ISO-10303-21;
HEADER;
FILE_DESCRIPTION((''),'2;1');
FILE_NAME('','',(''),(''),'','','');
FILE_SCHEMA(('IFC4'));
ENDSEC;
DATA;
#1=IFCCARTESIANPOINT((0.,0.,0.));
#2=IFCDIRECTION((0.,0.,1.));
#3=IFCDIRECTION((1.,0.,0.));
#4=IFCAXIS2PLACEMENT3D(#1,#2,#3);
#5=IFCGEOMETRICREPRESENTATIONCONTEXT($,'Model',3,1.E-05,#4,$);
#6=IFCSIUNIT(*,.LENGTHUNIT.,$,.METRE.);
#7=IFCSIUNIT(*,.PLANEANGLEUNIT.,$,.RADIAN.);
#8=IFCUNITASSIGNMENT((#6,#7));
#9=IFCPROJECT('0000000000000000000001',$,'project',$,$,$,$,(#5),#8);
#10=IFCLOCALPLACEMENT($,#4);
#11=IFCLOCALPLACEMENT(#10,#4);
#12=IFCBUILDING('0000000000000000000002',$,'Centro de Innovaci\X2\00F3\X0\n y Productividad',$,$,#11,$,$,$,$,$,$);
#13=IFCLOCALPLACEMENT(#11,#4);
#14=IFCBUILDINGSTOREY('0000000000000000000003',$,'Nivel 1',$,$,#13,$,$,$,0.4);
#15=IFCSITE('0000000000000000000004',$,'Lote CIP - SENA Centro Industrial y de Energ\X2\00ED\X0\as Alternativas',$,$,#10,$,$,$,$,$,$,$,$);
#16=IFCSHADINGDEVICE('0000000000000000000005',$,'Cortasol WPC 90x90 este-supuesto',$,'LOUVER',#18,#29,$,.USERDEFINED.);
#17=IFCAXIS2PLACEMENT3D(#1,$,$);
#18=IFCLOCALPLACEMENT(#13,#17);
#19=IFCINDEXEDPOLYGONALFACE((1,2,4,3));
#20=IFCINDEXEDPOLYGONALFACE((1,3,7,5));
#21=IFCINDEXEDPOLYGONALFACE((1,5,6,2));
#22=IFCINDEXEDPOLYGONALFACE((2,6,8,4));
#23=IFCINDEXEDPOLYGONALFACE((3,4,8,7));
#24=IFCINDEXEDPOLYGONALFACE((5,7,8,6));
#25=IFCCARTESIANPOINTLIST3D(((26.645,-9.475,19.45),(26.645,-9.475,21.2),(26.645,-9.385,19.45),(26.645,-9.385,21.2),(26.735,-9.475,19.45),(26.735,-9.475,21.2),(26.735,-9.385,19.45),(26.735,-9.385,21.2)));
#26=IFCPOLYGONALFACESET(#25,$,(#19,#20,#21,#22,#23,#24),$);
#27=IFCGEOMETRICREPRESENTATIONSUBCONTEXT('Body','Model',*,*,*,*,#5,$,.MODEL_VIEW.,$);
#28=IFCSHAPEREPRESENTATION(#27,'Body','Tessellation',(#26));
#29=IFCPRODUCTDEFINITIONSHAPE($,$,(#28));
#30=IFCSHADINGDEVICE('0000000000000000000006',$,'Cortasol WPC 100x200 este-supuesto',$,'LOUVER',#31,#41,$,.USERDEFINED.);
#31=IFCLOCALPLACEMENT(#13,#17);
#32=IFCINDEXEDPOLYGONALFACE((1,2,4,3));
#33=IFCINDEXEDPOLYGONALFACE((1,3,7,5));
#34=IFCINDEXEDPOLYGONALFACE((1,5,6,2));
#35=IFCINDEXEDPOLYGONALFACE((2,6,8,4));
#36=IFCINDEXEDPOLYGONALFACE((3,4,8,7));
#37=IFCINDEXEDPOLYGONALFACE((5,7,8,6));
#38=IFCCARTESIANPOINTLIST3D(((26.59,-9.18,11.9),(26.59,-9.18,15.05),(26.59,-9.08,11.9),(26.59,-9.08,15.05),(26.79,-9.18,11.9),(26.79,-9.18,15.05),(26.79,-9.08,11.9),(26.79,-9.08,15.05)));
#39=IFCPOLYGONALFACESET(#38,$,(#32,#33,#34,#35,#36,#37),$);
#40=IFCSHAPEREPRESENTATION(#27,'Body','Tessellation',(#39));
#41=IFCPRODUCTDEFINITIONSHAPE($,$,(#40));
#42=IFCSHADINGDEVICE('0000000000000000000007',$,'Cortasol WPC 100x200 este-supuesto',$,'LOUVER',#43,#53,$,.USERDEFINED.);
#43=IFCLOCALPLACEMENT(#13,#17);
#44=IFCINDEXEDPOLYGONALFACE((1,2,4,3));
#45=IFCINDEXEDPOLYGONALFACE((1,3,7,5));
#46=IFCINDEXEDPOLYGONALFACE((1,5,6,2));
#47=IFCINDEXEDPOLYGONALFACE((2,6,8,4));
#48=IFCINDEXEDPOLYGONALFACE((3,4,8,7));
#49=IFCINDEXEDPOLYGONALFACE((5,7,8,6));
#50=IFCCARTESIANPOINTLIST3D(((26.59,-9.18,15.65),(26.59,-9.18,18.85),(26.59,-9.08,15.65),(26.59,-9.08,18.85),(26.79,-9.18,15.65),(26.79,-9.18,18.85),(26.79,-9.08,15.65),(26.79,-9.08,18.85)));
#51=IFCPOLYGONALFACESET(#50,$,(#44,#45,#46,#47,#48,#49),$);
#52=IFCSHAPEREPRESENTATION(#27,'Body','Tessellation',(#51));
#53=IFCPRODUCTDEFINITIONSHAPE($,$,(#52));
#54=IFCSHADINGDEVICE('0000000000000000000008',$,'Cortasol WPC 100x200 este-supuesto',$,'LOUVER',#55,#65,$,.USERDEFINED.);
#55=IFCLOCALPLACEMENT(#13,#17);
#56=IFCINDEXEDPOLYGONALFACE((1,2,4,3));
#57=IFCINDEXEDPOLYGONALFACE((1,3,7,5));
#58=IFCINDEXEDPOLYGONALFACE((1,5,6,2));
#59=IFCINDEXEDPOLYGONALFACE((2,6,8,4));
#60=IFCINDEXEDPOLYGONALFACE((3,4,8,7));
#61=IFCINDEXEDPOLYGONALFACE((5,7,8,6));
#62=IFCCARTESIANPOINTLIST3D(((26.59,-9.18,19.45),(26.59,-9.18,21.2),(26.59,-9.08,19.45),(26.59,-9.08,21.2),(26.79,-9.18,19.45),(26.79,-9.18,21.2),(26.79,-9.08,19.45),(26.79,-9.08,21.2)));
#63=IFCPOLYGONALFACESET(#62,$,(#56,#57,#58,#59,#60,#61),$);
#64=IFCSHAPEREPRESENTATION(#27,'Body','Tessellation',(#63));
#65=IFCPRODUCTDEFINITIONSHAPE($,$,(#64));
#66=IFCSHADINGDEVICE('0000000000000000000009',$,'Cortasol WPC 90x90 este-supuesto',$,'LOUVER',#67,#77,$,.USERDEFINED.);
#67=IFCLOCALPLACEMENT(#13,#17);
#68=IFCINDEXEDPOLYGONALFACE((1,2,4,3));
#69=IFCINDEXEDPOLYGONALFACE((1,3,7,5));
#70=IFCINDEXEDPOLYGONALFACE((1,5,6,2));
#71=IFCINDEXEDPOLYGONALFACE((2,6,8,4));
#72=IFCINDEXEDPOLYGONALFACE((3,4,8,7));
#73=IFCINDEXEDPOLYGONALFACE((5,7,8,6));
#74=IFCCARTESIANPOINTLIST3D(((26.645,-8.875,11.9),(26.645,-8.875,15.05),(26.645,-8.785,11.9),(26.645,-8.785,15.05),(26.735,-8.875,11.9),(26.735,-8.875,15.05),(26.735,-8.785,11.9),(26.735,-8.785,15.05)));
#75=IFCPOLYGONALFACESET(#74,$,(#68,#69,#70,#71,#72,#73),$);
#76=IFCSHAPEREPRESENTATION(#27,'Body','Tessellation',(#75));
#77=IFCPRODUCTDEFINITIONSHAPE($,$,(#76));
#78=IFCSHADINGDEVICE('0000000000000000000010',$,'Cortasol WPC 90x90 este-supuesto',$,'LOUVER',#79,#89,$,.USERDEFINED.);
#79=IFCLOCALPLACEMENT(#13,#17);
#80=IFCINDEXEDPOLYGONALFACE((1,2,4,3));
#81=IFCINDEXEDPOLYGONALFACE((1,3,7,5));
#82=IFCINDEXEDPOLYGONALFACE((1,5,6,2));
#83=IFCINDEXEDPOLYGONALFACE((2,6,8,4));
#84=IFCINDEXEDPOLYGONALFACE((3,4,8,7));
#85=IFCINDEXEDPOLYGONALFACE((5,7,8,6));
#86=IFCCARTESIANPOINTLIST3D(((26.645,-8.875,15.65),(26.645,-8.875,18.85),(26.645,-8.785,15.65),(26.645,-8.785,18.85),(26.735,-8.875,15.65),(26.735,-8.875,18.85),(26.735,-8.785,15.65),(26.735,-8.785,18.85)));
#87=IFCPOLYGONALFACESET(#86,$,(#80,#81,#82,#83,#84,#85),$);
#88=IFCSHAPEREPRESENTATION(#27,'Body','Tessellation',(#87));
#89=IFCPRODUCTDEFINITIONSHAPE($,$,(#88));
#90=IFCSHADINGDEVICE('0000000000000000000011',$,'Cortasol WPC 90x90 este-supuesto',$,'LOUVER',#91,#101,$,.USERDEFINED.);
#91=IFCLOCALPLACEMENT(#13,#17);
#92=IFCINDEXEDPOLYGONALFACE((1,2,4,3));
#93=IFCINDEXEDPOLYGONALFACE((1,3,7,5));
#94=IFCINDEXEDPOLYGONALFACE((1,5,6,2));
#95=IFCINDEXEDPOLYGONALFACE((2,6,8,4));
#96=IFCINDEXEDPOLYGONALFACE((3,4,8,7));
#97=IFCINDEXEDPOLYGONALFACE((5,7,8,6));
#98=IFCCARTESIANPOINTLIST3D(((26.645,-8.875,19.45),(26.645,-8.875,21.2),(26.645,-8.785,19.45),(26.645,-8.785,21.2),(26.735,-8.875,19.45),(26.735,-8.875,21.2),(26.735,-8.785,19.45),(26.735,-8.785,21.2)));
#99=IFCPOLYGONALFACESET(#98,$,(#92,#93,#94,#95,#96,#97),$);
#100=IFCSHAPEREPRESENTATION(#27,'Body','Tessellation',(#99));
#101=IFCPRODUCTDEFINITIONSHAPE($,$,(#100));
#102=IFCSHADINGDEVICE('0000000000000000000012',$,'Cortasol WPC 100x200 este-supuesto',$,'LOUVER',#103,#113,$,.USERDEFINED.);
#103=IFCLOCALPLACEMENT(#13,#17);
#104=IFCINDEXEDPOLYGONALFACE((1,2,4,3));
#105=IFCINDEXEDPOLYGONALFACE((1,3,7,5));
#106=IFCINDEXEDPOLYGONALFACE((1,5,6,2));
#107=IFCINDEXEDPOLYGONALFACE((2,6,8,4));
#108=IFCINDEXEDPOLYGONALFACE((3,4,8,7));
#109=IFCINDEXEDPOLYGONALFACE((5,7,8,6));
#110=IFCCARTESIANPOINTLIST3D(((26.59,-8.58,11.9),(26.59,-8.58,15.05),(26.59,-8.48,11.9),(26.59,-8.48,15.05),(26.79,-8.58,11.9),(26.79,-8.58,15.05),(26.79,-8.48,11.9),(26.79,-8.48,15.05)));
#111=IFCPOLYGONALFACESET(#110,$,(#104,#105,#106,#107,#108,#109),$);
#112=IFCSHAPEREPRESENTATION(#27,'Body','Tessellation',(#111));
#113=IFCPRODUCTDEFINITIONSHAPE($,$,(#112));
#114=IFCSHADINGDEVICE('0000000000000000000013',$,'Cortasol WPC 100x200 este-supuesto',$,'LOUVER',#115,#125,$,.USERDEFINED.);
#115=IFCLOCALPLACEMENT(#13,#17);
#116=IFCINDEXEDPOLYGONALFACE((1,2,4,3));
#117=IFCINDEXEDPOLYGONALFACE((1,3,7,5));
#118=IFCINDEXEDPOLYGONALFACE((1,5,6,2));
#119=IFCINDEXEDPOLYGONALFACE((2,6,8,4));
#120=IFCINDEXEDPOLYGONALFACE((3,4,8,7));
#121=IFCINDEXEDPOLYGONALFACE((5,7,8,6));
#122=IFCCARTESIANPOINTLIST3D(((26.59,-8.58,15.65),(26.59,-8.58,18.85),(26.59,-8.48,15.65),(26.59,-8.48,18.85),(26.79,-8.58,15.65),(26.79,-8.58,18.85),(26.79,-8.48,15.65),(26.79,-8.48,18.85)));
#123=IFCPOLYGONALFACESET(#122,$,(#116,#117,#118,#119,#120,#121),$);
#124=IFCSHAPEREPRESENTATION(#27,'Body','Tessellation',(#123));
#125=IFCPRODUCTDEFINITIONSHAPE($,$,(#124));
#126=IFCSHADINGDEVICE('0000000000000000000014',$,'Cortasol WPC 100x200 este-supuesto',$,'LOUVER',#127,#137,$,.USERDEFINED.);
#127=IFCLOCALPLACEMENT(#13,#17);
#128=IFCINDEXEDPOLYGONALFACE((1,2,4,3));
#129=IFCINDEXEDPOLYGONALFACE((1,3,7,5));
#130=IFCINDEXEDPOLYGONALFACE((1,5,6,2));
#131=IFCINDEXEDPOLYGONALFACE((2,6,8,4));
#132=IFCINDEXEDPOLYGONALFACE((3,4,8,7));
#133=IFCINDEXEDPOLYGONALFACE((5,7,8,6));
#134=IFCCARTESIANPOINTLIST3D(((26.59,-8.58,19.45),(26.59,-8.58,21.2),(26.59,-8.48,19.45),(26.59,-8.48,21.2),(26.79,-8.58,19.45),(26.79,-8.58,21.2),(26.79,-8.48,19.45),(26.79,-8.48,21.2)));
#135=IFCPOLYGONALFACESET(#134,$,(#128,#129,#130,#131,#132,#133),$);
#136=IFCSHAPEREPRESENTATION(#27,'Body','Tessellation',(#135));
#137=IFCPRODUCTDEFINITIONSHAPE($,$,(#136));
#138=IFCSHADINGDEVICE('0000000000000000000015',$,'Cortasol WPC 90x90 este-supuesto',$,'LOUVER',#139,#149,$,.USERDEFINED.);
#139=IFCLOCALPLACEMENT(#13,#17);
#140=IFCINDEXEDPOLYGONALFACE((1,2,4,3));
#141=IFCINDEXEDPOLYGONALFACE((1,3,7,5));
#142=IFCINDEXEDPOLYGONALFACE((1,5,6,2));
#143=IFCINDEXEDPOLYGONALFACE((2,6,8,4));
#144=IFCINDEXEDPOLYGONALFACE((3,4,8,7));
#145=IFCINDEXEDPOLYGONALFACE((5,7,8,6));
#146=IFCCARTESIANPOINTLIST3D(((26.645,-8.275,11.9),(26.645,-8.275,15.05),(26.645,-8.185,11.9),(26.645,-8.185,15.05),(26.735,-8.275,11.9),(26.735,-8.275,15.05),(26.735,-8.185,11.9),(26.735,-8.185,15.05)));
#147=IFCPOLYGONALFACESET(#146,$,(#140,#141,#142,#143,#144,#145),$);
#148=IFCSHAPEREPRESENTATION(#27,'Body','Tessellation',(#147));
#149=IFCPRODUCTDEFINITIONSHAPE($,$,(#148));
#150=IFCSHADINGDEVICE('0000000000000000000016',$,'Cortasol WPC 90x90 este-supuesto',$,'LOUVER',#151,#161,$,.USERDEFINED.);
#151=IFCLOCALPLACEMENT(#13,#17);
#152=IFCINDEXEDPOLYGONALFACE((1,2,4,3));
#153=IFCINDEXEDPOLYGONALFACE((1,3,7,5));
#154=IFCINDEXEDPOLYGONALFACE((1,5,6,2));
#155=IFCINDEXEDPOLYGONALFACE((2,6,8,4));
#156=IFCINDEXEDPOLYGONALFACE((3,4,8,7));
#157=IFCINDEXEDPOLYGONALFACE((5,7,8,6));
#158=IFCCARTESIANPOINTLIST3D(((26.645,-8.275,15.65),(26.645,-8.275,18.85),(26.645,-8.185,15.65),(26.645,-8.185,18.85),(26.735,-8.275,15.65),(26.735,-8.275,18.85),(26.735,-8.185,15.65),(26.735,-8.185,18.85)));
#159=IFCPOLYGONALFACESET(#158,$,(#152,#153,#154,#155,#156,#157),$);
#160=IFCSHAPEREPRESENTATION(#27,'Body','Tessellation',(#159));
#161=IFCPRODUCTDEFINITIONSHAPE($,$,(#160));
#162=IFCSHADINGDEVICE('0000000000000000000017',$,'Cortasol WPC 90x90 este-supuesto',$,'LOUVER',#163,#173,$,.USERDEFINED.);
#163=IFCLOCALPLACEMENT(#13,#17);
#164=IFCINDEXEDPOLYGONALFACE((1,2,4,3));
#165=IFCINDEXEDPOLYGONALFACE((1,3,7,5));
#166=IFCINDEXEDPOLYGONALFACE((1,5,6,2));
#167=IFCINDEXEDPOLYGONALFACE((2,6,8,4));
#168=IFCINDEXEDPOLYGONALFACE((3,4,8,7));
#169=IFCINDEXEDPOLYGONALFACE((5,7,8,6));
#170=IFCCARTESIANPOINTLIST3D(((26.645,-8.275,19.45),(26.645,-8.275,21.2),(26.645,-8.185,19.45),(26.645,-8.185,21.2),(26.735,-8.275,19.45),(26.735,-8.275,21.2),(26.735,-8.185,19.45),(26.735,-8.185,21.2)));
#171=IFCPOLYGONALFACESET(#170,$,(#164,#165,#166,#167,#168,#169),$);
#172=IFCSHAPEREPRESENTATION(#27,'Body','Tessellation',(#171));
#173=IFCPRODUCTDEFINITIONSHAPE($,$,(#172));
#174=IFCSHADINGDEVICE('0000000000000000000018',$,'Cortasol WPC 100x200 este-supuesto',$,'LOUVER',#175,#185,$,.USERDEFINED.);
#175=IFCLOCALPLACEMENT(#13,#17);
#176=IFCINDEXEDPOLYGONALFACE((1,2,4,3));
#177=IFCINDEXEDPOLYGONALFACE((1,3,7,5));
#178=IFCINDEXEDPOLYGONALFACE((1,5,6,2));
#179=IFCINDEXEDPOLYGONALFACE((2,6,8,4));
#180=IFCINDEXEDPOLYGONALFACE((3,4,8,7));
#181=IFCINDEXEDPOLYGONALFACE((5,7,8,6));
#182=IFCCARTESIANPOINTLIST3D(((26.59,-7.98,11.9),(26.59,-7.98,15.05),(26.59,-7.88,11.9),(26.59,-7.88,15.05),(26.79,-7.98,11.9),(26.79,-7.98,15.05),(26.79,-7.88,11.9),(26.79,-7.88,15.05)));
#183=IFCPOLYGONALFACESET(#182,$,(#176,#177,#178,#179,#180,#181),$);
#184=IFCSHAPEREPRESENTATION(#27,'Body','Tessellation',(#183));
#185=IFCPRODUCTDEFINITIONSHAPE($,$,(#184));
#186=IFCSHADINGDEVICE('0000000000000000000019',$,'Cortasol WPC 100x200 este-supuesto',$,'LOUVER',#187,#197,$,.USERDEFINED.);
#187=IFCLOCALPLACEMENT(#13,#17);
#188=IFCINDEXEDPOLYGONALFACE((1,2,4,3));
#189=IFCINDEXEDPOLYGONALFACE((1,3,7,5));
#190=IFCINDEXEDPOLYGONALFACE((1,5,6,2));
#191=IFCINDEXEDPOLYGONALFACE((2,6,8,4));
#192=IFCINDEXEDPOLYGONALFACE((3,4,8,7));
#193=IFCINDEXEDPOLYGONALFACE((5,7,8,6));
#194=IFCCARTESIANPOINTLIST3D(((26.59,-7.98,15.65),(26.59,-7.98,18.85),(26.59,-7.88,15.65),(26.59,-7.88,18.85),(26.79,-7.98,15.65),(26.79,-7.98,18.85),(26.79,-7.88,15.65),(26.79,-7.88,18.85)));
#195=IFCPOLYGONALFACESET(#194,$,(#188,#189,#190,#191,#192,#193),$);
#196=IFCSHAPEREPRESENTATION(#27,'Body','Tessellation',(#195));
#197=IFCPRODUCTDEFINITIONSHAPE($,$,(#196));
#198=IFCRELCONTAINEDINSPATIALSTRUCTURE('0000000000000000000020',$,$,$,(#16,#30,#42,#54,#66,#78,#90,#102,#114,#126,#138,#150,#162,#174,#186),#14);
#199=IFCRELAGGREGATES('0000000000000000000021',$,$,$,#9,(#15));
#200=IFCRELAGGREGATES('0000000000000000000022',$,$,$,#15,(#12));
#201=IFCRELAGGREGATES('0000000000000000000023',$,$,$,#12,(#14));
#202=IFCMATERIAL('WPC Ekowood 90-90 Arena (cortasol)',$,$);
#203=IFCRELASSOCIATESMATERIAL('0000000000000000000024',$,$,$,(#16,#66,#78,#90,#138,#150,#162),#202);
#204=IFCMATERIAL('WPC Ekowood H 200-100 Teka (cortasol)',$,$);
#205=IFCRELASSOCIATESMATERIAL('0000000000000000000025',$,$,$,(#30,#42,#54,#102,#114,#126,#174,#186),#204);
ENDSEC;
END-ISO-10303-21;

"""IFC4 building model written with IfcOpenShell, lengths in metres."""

from ifc_helpers import new_model, si_unit, frame, origin_with_axes, place, context, subcontext, project, spatial, polyline, outline, extrude, material, element, save


model = new_model("IFC4")

# Units and contexts
model_context = context("Model", 3, precision=1e-05, world=origin_with_axes())
body_context = subcontext(model_context, "Body", "Model", "MODEL_VIEW")
ifc_project = project(units=[si_unit("LENGTHUNIT", "METRE"), si_unit("PLANEANGLEUNIT", "RADIAN")], contexts=[model_context])

# Site, building, storey
site_placement = place(None, origin_with_axes())
site = spatial("IfcSite", under=ifc_project, at=site_placement, Name="Lote CIP - SENA Centro Industrial y de Energías Alternativas")
building_placement = place(site_placement, origin_with_axes())
building = spatial("IfcBuilding", under=site, at=building_placement, Name="Centro de Innovación y Productividad")
storey_placement = place(building_placement, origin_with_axes())
storey = spatial("IfcBuildingStorey", under=building, at=storey_placement, Name="Nivel 1", Elevation=0.4)

# Shading devices
ifc_material_1 = material(Name="WPC Ekowood 90-90 Arena (cortasol)")
shading_device_1_placement = place(storey_placement, origin_with_axes())
element("IfcShadingDevice", 1, at=shading_device_1_placement, inside=storey, material=ifc_material_1, Name="Cortasol WPC 90x90 este-supuesto", ObjectType="LOUVER", PredefinedType="USERDEFINED", context=body_context, shape_type="SweptSolid", body=[
    extrude(outline(polyline([(26.735, -9.475), (26.645, -9.475), (26.645, -9.385), (26.735, -9.385), (26.735, -9.475)])), frame((0.0, 0.0, 19.45)), (0.0, 0.0, 1.0), 1.75),
])
ifc_material_2 = material(Name="WPC Ekowood H 200-100 Teka (cortasol)")
shading_device_2_placement = place(storey_placement, origin_with_axes())
element("IfcShadingDevice", 2, at=shading_device_2_placement, inside=storey, material=ifc_material_2, Name="Cortasol WPC 100x200 este-supuesto", ObjectType="LOUVER", PredefinedType="USERDEFINED", context=body_context, shape_type="SweptSolid", body=[
    extrude(outline(polyline([(26.79, -9.18), (26.59, -9.18), (26.59, -9.08), (26.79, -9.08), (26.79, -9.18)])), frame((0.0, 0.0, 11.9)), (0.0, 0.0, 1.0), 3.15),
])
shading_device_3_placement = place(storey_placement, origin_with_axes())
element("IfcShadingDevice", 3, at=shading_device_3_placement, inside=storey, material=ifc_material_2, Name="Cortasol WPC 100x200 este-supuesto", ObjectType="LOUVER", PredefinedType="USERDEFINED", context=body_context, shape_type="SweptSolid", body=[
    extrude(outline(polyline([(26.79, -9.18), (26.59, -9.18), (26.59, -9.08), (26.79, -9.08), (26.79, -9.18)])), frame((0.0, 0.0, 15.65)), (0.0, 0.0, 1.0), 3.2),
])
shading_device_4_placement = place(storey_placement, origin_with_axes())
element("IfcShadingDevice", 4, at=shading_device_4_placement, inside=storey, material=ifc_material_2, Name="Cortasol WPC 100x200 este-supuesto", ObjectType="LOUVER", PredefinedType="USERDEFINED", context=body_context, shape_type="SweptSolid", body=[
    extrude(outline(polyline([(26.79, -9.18), (26.59, -9.18), (26.59, -9.08), (26.79, -9.08), (26.79, -9.18)])), frame((0.0, 0.0, 19.45)), (0.0, 0.0, 1.0), 1.75),
])
shading_device_5_placement = place(storey_placement, origin_with_axes())
element("IfcShadingDevice", 5, at=shading_device_5_placement, inside=storey, material=ifc_material_1, Name="Cortasol WPC 90x90 este-supuesto", ObjectType="LOUVER", PredefinedType="USERDEFINED", context=body_context, shape_type="SweptSolid", body=[
    extrude(outline(polyline([(26.735, -8.875), (26.645, -8.875), (26.645, -8.785), (26.735, -8.785), (26.735, -8.875)])), frame((0.0, 0.0, 11.9)), (0.0, 0.0, 1.0), 3.15),
])
shading_device_6_placement = place(storey_placement, origin_with_axes())
element("IfcShadingDevice", 6, at=shading_device_6_placement, inside=storey, material=ifc_material_1, Name="Cortasol WPC 90x90 este-supuesto", ObjectType="LOUVER", PredefinedType="USERDEFINED", context=body_context, shape_type="SweptSolid", body=[
    extrude(outline(polyline([(26.735, -8.875), (26.645, -8.875), (26.645, -8.785), (26.735, -8.785), (26.735, -8.875)])), frame((0.0, 0.0, 15.65)), (0.0, 0.0, 1.0), 3.2),
])
shading_device_7_placement = place(storey_placement, origin_with_axes())
element("IfcShadingDevice", 7, at=shading_device_7_placement, inside=storey, material=ifc_material_1, Name="Cortasol WPC 90x90 este-supuesto", ObjectType="LOUVER", PredefinedType="USERDEFINED", context=body_context, shape_type="SweptSolid", body=[
    extrude(outline(polyline([(26.735, -8.875), (26.645, -8.875), (26.645, -8.785), (26.735, -8.785), (26.735, -8.875)])), frame((0.0, 0.0, 19.45)), (0.0, 0.0, 1.0), 1.75),
])
shading_device_8_placement = place(storey_placement, origin_with_axes())
element("IfcShadingDevice", 8, at=shading_device_8_placement, inside=storey, material=ifc_material_2, Name="Cortasol WPC 100x200 este-supuesto", ObjectType="LOUVER", PredefinedType="USERDEFINED", context=body_context, shape_type="SweptSolid", body=[
    extrude(outline(polyline([(26.79, -8.58), (26.59, -8.58), (26.59, -8.48), (26.79, -8.48), (26.79, -8.58)])), frame((0.0, 0.0, 11.9)), (0.0, 0.0, 1.0), 3.15),
])
shading_device_9_placement = place(storey_placement, origin_with_axes())
element("IfcShadingDevice", 9, at=shading_device_9_placement, inside=storey, material=ifc_material_2, Name="Cortasol WPC 100x200 este-supuesto", ObjectType="LOUVER", PredefinedType="USERDEFINED", context=body_context, shape_type="SweptSolid", body=[
    extrude(outline(polyline([(26.79, -8.58), (26.59, -8.58), (26.59, -8.48), (26.79, -8.48), (26.79, -8.58)])), frame((0.0, 0.0, 15.65)), (0.0, 0.0, 1.0), 3.2),
])
shading_device_10_placement = place(storey_placement, origin_with_axes())
element("IfcShadingDevice", 10, at=shading_device_10_placement, inside=storey, material=ifc_material_2, Name="Cortasol WPC 100x200 este-supuesto", ObjectType="LOUVER", PredefinedType="USERDEFINED", context=body_context, shape_type="SweptSolid", body=[
    extrude(outline(polyline([(26.79, -8.58), (26.59, -8.58), (26.59, -8.48), (26.79, -8.48), (26.79, -8.58)])), frame((0.0, 0.0, 19.45)), (0.0, 0.0, 1.0), 1.75),
])
shading_device_11_placement = place(storey_placement, origin_with_axes())
element("IfcShadingDevice", 11, at=shading_device_11_placement, inside=storey, material=ifc_material_1, Name="Cortasol WPC 90x90 este-supuesto", ObjectType="LOUVER", PredefinedType="USERDEFINED", context=body_context, shape_type="SweptSolid", body=[
    extrude(outline(polyline([(26.735, -8.275), (26.645, -8.275), (26.645, -8.185), (26.735, -8.185), (26.735, -8.275)])), frame((0.0, 0.0, 11.9)), (0.0, 0.0, 1.0), 3.15),
])
shading_device_12_placement = place(storey_placement, origin_with_axes())
element("IfcShadingDevice", 12, at=shading_device_12_placement, inside=storey, material=ifc_material_1, Name="Cortasol WPC 90x90 este-supuesto", ObjectType="LOUVER", PredefinedType="USERDEFINED", context=body_context, shape_type="SweptSolid", body=[
    extrude(outline(polyline([(26.735, -8.275), (26.645, -8.275), (26.645, -8.185), (26.735, -8.185), (26.735, -8.275)])), frame((0.0, 0.0, 15.65)), (0.0, 0.0, 1.0), 3.2),
])
shading_device_13_placement = place(storey_placement, origin_with_axes())
element("IfcShadingDevice", 13, at=shading_device_13_placement, inside=storey, material=ifc_material_1, Name="Cortasol WPC 90x90 este-supuesto", ObjectType="LOUVER", PredefinedType="USERDEFINED", context=body_context, shape_type="SweptSolid", body=[
    extrude(outline(polyline([(26.735, -8.275), (26.645, -8.275), (26.645, -8.185), (26.735, -8.185), (26.735, -8.275)])), frame((0.0, 0.0, 19.45)), (0.0, 0.0, 1.0), 1.75),
])
shading_device_14_placement = place(storey_placement, origin_with_axes())
element("IfcShadingDevice", 14, at=shading_device_14_placement, inside=storey, material=ifc_material_2, Name="Cortasol WPC 100x200 este-supuesto", ObjectType="LOUVER", PredefinedType="USERDEFINED", context=body_context, shape_type="SweptSolid", body=[
    extrude(outline(polyline([(26.79, -7.98), (26.59, -7.98), (26.59, -7.88), (26.79, -7.88), (26.79, -7.98)])), frame((0.0, 0.0, 11.9)), (0.0, 0.0, 1.0), 3.15),
])
shading_device_15_placement = place(storey_placement, origin_with_axes())
element("IfcShadingDevice", 15, at=shading_device_15_placement, inside=storey, material=ifc_material_2, Name="Cortasol WPC 100x200 este-supuesto", ObjectType="LOUVER", PredefinedType="USERDEFINED", context=body_context, shape_type="SweptSolid", body=[
    extrude(outline(polyline([(26.79, -7.98), (26.59, -7.98), (26.59, -7.88), (26.79, -7.88), (26.79, -7.98)])), frame((0.0, 0.0, 15.65)), (0.0, 0.0, 1.0), 3.2),
])

save(model, "model.ifc")
